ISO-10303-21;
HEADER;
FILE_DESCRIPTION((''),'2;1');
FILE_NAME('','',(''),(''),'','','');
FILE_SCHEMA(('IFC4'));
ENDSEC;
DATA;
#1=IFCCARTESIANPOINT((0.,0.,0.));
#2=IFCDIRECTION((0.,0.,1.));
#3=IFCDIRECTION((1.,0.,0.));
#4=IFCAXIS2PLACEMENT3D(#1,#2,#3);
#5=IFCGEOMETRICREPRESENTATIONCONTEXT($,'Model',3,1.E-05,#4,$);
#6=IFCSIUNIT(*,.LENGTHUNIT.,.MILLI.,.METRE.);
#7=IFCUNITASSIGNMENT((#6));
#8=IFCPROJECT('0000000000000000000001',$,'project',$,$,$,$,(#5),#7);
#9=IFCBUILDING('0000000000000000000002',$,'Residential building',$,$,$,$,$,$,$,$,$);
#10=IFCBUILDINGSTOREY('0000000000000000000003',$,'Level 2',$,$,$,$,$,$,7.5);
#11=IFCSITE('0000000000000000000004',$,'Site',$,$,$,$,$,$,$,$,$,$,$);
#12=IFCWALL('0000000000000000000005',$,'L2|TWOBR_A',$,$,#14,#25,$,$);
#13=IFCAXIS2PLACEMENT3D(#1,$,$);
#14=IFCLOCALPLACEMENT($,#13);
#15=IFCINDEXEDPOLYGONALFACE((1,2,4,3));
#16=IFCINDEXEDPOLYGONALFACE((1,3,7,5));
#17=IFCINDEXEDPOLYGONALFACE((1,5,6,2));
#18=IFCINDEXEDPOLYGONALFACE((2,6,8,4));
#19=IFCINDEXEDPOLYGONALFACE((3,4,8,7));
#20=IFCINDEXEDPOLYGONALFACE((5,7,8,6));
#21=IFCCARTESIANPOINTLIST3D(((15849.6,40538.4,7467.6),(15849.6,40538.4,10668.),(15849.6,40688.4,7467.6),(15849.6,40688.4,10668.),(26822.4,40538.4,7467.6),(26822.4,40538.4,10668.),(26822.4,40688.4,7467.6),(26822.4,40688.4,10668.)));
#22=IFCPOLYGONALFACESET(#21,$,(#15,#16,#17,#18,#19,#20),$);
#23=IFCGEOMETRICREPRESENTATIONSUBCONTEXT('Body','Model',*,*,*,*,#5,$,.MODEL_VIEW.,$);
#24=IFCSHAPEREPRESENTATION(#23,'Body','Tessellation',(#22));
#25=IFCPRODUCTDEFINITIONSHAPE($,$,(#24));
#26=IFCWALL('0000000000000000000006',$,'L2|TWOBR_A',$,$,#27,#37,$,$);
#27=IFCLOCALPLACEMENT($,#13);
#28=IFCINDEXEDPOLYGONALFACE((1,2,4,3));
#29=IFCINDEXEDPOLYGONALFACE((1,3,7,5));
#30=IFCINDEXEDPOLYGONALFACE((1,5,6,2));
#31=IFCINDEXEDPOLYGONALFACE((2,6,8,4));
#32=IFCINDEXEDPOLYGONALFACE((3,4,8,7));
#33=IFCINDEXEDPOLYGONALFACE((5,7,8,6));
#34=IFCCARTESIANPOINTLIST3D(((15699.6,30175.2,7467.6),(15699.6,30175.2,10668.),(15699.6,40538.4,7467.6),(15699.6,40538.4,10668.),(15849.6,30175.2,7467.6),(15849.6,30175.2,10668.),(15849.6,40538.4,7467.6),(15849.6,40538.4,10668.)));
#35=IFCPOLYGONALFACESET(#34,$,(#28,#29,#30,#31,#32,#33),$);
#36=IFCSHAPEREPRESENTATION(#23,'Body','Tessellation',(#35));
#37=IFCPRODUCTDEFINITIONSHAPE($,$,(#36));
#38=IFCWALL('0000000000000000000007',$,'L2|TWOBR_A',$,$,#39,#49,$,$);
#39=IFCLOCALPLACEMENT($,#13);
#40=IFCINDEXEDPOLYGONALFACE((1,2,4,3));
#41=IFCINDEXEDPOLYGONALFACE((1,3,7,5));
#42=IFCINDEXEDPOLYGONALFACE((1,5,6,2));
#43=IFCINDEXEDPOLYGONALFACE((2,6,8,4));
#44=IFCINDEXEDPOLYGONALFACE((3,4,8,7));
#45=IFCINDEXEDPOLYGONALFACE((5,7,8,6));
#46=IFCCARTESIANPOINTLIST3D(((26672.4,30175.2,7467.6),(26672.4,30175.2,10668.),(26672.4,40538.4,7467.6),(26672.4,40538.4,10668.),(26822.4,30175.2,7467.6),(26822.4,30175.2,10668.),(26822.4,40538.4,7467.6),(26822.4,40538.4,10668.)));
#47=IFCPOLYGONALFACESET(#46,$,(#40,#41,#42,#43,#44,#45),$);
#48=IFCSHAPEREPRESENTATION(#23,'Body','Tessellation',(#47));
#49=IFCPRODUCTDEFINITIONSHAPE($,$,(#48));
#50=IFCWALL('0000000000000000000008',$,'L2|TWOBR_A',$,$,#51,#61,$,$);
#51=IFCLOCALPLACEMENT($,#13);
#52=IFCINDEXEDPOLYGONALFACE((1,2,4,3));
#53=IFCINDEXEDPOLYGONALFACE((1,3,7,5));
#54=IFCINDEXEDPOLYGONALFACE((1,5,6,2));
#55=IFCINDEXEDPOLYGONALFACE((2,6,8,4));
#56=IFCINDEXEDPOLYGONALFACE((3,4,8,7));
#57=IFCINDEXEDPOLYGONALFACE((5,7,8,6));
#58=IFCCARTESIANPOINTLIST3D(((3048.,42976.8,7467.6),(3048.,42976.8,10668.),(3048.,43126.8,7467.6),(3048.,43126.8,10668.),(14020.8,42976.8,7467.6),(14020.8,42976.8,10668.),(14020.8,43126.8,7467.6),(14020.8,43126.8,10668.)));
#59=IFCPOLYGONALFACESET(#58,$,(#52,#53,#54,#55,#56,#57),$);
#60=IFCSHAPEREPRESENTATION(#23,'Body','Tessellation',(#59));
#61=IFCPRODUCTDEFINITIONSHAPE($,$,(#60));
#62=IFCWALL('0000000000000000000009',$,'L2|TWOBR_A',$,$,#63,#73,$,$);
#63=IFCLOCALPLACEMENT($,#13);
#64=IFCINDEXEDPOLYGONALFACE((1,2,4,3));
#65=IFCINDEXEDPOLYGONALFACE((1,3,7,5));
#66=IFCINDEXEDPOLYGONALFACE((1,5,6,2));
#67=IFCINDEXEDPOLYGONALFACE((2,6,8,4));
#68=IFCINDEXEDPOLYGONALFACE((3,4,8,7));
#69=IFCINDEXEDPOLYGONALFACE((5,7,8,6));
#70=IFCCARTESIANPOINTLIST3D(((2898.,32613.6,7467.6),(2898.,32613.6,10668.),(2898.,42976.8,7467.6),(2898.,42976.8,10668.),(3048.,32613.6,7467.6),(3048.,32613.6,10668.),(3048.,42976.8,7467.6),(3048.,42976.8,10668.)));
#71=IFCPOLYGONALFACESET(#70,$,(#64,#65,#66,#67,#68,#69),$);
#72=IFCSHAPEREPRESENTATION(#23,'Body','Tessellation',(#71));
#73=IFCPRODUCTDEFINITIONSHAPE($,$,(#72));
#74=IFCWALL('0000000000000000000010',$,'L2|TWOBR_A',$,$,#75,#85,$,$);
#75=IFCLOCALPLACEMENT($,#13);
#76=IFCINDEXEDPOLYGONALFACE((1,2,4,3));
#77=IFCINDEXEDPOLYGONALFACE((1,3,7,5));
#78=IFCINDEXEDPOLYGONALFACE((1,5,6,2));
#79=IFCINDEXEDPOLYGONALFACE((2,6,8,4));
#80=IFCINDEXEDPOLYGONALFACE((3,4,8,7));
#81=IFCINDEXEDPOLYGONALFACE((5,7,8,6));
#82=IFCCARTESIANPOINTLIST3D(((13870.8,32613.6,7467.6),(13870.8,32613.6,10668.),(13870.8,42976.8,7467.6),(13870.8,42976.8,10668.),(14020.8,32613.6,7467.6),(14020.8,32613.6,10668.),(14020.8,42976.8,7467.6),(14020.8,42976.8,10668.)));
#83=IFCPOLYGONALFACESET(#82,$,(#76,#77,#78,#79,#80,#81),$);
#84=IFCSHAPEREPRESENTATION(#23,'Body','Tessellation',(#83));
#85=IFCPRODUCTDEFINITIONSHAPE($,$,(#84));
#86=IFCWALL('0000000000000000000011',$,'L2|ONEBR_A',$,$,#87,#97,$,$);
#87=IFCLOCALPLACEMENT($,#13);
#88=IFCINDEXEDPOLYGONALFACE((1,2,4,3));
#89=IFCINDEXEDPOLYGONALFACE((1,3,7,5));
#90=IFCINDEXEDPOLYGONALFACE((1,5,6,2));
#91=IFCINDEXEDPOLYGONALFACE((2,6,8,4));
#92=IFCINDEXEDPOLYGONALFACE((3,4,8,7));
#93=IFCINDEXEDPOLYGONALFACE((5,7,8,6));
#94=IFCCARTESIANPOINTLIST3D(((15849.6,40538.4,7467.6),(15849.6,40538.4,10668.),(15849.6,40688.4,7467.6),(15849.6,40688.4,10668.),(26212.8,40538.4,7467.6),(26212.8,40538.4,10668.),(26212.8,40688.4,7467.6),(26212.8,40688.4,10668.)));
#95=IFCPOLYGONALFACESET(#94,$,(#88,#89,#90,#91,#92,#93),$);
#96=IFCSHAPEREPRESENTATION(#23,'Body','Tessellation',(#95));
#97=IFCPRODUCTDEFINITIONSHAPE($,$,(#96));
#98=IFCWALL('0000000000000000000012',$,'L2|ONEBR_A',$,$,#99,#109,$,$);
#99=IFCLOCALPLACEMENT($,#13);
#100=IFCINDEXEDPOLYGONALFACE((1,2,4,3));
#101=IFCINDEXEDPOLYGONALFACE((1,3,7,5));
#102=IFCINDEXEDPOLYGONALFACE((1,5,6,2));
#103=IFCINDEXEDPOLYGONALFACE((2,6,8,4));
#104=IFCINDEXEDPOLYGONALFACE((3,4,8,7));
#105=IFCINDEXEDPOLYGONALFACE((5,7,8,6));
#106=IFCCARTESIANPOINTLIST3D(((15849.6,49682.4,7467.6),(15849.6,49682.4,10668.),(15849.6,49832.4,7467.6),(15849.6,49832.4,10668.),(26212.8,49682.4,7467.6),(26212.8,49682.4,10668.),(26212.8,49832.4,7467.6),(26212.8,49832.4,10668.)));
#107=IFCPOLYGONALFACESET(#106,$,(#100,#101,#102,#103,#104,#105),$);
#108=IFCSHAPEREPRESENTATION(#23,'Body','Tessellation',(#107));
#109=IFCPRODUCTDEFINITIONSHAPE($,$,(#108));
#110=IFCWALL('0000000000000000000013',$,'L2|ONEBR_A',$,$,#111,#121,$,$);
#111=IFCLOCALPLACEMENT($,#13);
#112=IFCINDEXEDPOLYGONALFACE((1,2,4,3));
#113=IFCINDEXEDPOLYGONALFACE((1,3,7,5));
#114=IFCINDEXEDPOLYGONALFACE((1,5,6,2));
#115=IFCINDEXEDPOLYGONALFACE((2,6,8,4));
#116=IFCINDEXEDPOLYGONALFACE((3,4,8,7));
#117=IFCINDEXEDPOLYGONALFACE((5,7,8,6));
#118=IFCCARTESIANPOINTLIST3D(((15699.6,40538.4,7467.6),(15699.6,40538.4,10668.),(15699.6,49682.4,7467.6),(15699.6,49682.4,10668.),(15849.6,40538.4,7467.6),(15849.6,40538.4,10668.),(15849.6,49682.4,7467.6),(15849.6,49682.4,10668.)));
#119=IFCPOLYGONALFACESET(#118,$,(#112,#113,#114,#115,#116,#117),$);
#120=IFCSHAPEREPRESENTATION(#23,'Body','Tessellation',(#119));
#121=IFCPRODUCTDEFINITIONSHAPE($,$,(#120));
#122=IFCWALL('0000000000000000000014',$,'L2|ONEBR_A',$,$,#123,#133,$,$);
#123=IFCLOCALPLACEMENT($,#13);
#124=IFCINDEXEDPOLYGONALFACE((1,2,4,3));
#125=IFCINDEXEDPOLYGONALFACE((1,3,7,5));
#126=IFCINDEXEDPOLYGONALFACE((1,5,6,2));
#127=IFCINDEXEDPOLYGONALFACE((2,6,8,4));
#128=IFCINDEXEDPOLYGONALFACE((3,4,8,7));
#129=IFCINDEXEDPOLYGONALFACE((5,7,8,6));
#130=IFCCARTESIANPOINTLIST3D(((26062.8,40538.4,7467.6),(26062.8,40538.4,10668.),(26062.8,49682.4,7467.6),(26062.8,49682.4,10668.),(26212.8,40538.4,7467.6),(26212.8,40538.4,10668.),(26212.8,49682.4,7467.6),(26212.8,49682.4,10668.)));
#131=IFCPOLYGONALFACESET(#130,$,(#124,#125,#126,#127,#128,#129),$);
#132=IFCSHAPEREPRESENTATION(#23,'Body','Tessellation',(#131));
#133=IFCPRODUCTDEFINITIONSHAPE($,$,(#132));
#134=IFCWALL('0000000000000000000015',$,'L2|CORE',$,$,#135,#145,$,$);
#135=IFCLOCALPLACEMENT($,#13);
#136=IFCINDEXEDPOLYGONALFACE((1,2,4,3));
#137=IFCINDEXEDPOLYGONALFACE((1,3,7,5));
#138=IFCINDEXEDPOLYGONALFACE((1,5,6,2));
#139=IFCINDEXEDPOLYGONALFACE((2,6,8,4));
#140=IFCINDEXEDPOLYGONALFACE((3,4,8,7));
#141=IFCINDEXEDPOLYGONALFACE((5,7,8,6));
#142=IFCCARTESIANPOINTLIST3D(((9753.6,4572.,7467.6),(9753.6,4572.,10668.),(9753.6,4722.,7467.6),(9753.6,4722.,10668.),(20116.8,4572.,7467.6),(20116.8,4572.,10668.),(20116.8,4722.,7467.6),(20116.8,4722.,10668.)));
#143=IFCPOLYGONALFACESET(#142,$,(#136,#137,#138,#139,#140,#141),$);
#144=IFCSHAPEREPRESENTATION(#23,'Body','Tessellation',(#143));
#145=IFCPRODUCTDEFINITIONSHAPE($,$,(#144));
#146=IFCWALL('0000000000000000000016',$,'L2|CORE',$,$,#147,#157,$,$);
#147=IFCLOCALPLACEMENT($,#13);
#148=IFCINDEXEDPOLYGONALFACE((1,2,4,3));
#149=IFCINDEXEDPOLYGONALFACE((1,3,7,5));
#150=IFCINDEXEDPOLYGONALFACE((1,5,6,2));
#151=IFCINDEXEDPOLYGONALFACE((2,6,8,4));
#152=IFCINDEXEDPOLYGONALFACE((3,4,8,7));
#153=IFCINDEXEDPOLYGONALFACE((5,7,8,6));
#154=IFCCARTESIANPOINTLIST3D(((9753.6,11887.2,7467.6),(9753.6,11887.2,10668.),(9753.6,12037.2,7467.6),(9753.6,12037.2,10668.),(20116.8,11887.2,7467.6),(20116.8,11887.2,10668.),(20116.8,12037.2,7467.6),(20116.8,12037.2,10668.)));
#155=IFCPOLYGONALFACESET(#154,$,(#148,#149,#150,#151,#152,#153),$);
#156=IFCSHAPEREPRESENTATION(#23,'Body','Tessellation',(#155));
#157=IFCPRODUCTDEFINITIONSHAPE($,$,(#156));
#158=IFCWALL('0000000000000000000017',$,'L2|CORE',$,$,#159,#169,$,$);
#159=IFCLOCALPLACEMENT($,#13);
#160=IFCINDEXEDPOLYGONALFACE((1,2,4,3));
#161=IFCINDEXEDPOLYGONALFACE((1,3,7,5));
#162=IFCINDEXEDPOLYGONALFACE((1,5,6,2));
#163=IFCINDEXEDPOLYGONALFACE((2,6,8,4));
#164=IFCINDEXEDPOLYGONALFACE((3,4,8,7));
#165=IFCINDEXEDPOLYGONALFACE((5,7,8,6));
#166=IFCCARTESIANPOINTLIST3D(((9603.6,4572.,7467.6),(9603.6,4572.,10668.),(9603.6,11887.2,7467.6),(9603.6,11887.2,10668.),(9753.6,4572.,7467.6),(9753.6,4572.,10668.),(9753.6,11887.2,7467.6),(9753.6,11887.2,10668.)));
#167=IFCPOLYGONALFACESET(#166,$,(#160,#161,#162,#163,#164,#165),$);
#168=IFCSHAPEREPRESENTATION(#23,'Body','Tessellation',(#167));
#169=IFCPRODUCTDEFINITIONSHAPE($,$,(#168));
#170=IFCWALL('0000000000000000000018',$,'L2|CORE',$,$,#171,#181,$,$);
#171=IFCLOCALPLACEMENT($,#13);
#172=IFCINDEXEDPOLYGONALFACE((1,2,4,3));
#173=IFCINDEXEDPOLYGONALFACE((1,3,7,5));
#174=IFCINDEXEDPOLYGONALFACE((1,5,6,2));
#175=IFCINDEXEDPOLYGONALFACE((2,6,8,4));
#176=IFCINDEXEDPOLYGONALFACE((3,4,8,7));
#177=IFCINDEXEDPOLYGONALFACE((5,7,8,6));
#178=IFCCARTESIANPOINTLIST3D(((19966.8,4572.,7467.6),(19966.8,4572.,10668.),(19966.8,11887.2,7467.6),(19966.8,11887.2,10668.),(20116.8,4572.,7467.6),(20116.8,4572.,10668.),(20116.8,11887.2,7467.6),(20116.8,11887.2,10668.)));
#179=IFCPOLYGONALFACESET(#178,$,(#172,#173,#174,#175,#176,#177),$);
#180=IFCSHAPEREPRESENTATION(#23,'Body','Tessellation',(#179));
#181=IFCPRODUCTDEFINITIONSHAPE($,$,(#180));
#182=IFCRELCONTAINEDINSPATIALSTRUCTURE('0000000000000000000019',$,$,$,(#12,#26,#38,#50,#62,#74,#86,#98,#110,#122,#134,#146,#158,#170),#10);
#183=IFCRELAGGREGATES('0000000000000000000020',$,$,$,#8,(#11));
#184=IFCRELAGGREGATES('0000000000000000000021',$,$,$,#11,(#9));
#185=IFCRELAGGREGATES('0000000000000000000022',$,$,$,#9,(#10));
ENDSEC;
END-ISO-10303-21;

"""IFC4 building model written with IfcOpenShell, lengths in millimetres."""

from ifc_helpers import new_model, si_unit, frame, origin_with_axes, place, context, subcontext, project, spatial, indexed_curve, outline, extrude, element, save


model = new_model("IFC4")

# Units and contexts
model_context = context("Model", 3, precision=1e-05, world=origin_with_axes())
body_context = subcontext(model_context, "Body", "Model", "MODEL_VIEW")
ifc_project = project(units=[si_unit("LENGTHUNIT", "METRE", prefix="MILLI")], contexts=[model_context])

# Site, building, storey
site = spatial("IfcSite", under=ifc_project, Name="Site")
building = spatial("IfcBuilding", under=site, Name="Residential building")
storey = spatial("IfcBuildingStorey", under=building, Name="Level 2", Elevation=7.5)

# Walls
for number, where, z_axis, x_axis, name in (
    (1, (15849.6, 40538.4, 7467.6), (0.0, 0.0, 1.0), (1.0, 0.0, 0.0), "L2|TWOBR_A"),
):
    element("IfcWall", number, at=place(None, frame(where, z_axis=z_axis, x_axis=x_axis)), inside=storey, Name=name, context=body_context, shape_type="SweptSolid", body=[
        extrude(outline(indexed_curve([(0.0, 0.0), (0.0, 150.0), (10972.8, 150.0), (10972.8, 0.0), (0.0, 0.0)], self_intersect=False)), origin_with_axes(), (0.0, 0.0, 1.0), 3200.4),
    ])
for number, where, z_axis, x_axis, name in (
    (2, (15849.6, 30175.2, 7467.6), (0.0, 0.0, 1.0), (0.0, 1.0, 0.0), "L2|TWOBR_A"),
    (3, (26822.4, 30175.2, 7467.6), (0.0, 0.0, 1.0), (0.0, 1.0, 0.0), "L2|TWOBR_A"),
):
    element("IfcWall", number, at=place(None, frame(where, z_axis=z_axis, x_axis=x_axis)), inside=storey, Name=name, context=body_context, shape_type="SweptSolid", body=[
        extrude(outline(indexed_curve([(0.0, 0.0), (0.0, 150.0), (10363.2, 150.0), (10363.2, 0.0), (0.0, 0.0)], self_intersect=False)), origin_with_axes(), (0.0, 0.0, 1.0), 3200.4),
    ])
for number, where, z_axis, x_axis, name in (
    (4, (3048.0, 42976.8, 7467.6), (0.0, 0.0, 1.0), (1.0, 0.0, 0.0), "L2|TWOBR_A"),
):
    element("IfcWall", number, at=place(None, frame(where, z_axis=z_axis, x_axis=x_axis)), inside=storey, Name=name, context=body_context, shape_type="SweptSolid", body=[
        extrude(outline(indexed_curve([(0.0, 0.0), (0.0, 150.0), (10972.8, 150.0), (10972.8, 0.0), (0.0, 0.0)], self_intersect=False)), origin_with_axes(), (0.0, 0.0, 1.0), 3200.4),
    ])
for number, where, z_axis, x_axis, name in (
    (5, (3048.0, 32613.6, 7467.6), (0.0, 0.0, 1.0), (0.0, 1.0, 0.0), "L2|TWOBR_A"),
    (6, (14020.8, 32613.6, 7467.6), (0.0, 0.0, 1.0), (0.0, 1.0, 0.0), "L2|TWOBR_A"),
    (7, (15849.6, 40538.4, 7467.6), (0.0, 0.0, 1.0), (1.0, 0.0, 0.0), "L2|ONEBR_A"),
    (8, (15849.6, 49682.4, 7467.6), (0.0, 0.0, 1.0), (1.0, 0.0, 0.0), "L2|ONEBR_A"),
):
    element("IfcWall", number, at=place(None, frame(where, z_axis=z_axis, x_axis=x_axis)), inside=storey, Name=name, context=body_context, shape_type="SweptSolid", body=[
        extrude(outline(indexed_curve([(0.0, 0.0), (0.0, 150.0), (10363.2, 150.0), (10363.2, 0.0), (0.0, 0.0)], self_intersect=False)), origin_with_axes(), (0.0, 0.0, 1.0), 3200.4),
    ])
for number, where, z_axis, x_axis, name in (
    (9, (15849.6, 40538.4, 7467.6), (0.0, 0.0, 1.0), (0.0, 1.0, 0.0), "L2|ONEBR_A"),
    (10, (26212.8, 40538.4, 7467.6), (0.0, 0.0, 1.0), (0.0, 1.0, 0.0), "L2|ONEBR_A"),
):
    element("IfcWall", number, at=place(None, frame(where, z_axis=z_axis, x_axis=x_axis)), inside=storey, Name=name, context=body_context, shape_type="SweptSolid", body=[
        extrude(outline(indexed_curve([(0.0, 0.0), (0.0, 150.0), (9144.0, 150.0), (9144.0, 0.0), (0.0, 0.0)], self_intersect=False)), origin_with_axes(), (0.0, 0.0, 1.0), 3200.4),
    ])
for number, where, z_axis, x_axis, name in (
    (11, (9753.6, 4572.0, 7467.6), (0.0, 0.0, 1.0), (1.0, 0.0, 0.0), "L2|CORE"),
    (12, (9753.6, 11887.2, 7467.6), (0.0, 0.0, 1.0), (1.0, 0.0, 0.0), "L2|CORE"),
):
    element("IfcWall", number, at=place(None, frame(where, z_axis=z_axis, x_axis=x_axis)), inside=storey, Name=name, context=body_context, shape_type="SweptSolid", body=[
        extrude(outline(indexed_curve([(0.0, 0.0), (0.0, 150.0), (10363.2, 150.0), (10363.2, 0.0), (0.0, 0.0)], self_intersect=False)), origin_with_axes(), (0.0, 0.0, 1.0), 3200.4),
    ])
for number, where, z_axis, x_axis, name in (
    (13, (9753.6, 4572.0, 7467.6), (0.0, 0.0, 1.0), (0.0, 1.0, 0.0), "L2|CORE"),
    (14, (20116.8, 4572.0, 7467.6), (0.0, 0.0, 1.0), (0.0, 1.0, 0.0), "L2|CORE"),
):
    element("IfcWall", number, at=place(None, frame(where, z_axis=z_axis, x_axis=x_axis)), inside=storey, Name=name, context=body_context, shape_type="SweptSolid", body=[
        extrude(outline(indexed_curve([(0.0, 0.0), (0.0, 150.0), (7315.2, 150.0), (7315.2, 0.0), (0.0, 0.0)], self_intersect=False)), origin_with_axes(), (0.0, 0.0, 1.0), 3200.4),
    ])

save(model, "model.ifc")
